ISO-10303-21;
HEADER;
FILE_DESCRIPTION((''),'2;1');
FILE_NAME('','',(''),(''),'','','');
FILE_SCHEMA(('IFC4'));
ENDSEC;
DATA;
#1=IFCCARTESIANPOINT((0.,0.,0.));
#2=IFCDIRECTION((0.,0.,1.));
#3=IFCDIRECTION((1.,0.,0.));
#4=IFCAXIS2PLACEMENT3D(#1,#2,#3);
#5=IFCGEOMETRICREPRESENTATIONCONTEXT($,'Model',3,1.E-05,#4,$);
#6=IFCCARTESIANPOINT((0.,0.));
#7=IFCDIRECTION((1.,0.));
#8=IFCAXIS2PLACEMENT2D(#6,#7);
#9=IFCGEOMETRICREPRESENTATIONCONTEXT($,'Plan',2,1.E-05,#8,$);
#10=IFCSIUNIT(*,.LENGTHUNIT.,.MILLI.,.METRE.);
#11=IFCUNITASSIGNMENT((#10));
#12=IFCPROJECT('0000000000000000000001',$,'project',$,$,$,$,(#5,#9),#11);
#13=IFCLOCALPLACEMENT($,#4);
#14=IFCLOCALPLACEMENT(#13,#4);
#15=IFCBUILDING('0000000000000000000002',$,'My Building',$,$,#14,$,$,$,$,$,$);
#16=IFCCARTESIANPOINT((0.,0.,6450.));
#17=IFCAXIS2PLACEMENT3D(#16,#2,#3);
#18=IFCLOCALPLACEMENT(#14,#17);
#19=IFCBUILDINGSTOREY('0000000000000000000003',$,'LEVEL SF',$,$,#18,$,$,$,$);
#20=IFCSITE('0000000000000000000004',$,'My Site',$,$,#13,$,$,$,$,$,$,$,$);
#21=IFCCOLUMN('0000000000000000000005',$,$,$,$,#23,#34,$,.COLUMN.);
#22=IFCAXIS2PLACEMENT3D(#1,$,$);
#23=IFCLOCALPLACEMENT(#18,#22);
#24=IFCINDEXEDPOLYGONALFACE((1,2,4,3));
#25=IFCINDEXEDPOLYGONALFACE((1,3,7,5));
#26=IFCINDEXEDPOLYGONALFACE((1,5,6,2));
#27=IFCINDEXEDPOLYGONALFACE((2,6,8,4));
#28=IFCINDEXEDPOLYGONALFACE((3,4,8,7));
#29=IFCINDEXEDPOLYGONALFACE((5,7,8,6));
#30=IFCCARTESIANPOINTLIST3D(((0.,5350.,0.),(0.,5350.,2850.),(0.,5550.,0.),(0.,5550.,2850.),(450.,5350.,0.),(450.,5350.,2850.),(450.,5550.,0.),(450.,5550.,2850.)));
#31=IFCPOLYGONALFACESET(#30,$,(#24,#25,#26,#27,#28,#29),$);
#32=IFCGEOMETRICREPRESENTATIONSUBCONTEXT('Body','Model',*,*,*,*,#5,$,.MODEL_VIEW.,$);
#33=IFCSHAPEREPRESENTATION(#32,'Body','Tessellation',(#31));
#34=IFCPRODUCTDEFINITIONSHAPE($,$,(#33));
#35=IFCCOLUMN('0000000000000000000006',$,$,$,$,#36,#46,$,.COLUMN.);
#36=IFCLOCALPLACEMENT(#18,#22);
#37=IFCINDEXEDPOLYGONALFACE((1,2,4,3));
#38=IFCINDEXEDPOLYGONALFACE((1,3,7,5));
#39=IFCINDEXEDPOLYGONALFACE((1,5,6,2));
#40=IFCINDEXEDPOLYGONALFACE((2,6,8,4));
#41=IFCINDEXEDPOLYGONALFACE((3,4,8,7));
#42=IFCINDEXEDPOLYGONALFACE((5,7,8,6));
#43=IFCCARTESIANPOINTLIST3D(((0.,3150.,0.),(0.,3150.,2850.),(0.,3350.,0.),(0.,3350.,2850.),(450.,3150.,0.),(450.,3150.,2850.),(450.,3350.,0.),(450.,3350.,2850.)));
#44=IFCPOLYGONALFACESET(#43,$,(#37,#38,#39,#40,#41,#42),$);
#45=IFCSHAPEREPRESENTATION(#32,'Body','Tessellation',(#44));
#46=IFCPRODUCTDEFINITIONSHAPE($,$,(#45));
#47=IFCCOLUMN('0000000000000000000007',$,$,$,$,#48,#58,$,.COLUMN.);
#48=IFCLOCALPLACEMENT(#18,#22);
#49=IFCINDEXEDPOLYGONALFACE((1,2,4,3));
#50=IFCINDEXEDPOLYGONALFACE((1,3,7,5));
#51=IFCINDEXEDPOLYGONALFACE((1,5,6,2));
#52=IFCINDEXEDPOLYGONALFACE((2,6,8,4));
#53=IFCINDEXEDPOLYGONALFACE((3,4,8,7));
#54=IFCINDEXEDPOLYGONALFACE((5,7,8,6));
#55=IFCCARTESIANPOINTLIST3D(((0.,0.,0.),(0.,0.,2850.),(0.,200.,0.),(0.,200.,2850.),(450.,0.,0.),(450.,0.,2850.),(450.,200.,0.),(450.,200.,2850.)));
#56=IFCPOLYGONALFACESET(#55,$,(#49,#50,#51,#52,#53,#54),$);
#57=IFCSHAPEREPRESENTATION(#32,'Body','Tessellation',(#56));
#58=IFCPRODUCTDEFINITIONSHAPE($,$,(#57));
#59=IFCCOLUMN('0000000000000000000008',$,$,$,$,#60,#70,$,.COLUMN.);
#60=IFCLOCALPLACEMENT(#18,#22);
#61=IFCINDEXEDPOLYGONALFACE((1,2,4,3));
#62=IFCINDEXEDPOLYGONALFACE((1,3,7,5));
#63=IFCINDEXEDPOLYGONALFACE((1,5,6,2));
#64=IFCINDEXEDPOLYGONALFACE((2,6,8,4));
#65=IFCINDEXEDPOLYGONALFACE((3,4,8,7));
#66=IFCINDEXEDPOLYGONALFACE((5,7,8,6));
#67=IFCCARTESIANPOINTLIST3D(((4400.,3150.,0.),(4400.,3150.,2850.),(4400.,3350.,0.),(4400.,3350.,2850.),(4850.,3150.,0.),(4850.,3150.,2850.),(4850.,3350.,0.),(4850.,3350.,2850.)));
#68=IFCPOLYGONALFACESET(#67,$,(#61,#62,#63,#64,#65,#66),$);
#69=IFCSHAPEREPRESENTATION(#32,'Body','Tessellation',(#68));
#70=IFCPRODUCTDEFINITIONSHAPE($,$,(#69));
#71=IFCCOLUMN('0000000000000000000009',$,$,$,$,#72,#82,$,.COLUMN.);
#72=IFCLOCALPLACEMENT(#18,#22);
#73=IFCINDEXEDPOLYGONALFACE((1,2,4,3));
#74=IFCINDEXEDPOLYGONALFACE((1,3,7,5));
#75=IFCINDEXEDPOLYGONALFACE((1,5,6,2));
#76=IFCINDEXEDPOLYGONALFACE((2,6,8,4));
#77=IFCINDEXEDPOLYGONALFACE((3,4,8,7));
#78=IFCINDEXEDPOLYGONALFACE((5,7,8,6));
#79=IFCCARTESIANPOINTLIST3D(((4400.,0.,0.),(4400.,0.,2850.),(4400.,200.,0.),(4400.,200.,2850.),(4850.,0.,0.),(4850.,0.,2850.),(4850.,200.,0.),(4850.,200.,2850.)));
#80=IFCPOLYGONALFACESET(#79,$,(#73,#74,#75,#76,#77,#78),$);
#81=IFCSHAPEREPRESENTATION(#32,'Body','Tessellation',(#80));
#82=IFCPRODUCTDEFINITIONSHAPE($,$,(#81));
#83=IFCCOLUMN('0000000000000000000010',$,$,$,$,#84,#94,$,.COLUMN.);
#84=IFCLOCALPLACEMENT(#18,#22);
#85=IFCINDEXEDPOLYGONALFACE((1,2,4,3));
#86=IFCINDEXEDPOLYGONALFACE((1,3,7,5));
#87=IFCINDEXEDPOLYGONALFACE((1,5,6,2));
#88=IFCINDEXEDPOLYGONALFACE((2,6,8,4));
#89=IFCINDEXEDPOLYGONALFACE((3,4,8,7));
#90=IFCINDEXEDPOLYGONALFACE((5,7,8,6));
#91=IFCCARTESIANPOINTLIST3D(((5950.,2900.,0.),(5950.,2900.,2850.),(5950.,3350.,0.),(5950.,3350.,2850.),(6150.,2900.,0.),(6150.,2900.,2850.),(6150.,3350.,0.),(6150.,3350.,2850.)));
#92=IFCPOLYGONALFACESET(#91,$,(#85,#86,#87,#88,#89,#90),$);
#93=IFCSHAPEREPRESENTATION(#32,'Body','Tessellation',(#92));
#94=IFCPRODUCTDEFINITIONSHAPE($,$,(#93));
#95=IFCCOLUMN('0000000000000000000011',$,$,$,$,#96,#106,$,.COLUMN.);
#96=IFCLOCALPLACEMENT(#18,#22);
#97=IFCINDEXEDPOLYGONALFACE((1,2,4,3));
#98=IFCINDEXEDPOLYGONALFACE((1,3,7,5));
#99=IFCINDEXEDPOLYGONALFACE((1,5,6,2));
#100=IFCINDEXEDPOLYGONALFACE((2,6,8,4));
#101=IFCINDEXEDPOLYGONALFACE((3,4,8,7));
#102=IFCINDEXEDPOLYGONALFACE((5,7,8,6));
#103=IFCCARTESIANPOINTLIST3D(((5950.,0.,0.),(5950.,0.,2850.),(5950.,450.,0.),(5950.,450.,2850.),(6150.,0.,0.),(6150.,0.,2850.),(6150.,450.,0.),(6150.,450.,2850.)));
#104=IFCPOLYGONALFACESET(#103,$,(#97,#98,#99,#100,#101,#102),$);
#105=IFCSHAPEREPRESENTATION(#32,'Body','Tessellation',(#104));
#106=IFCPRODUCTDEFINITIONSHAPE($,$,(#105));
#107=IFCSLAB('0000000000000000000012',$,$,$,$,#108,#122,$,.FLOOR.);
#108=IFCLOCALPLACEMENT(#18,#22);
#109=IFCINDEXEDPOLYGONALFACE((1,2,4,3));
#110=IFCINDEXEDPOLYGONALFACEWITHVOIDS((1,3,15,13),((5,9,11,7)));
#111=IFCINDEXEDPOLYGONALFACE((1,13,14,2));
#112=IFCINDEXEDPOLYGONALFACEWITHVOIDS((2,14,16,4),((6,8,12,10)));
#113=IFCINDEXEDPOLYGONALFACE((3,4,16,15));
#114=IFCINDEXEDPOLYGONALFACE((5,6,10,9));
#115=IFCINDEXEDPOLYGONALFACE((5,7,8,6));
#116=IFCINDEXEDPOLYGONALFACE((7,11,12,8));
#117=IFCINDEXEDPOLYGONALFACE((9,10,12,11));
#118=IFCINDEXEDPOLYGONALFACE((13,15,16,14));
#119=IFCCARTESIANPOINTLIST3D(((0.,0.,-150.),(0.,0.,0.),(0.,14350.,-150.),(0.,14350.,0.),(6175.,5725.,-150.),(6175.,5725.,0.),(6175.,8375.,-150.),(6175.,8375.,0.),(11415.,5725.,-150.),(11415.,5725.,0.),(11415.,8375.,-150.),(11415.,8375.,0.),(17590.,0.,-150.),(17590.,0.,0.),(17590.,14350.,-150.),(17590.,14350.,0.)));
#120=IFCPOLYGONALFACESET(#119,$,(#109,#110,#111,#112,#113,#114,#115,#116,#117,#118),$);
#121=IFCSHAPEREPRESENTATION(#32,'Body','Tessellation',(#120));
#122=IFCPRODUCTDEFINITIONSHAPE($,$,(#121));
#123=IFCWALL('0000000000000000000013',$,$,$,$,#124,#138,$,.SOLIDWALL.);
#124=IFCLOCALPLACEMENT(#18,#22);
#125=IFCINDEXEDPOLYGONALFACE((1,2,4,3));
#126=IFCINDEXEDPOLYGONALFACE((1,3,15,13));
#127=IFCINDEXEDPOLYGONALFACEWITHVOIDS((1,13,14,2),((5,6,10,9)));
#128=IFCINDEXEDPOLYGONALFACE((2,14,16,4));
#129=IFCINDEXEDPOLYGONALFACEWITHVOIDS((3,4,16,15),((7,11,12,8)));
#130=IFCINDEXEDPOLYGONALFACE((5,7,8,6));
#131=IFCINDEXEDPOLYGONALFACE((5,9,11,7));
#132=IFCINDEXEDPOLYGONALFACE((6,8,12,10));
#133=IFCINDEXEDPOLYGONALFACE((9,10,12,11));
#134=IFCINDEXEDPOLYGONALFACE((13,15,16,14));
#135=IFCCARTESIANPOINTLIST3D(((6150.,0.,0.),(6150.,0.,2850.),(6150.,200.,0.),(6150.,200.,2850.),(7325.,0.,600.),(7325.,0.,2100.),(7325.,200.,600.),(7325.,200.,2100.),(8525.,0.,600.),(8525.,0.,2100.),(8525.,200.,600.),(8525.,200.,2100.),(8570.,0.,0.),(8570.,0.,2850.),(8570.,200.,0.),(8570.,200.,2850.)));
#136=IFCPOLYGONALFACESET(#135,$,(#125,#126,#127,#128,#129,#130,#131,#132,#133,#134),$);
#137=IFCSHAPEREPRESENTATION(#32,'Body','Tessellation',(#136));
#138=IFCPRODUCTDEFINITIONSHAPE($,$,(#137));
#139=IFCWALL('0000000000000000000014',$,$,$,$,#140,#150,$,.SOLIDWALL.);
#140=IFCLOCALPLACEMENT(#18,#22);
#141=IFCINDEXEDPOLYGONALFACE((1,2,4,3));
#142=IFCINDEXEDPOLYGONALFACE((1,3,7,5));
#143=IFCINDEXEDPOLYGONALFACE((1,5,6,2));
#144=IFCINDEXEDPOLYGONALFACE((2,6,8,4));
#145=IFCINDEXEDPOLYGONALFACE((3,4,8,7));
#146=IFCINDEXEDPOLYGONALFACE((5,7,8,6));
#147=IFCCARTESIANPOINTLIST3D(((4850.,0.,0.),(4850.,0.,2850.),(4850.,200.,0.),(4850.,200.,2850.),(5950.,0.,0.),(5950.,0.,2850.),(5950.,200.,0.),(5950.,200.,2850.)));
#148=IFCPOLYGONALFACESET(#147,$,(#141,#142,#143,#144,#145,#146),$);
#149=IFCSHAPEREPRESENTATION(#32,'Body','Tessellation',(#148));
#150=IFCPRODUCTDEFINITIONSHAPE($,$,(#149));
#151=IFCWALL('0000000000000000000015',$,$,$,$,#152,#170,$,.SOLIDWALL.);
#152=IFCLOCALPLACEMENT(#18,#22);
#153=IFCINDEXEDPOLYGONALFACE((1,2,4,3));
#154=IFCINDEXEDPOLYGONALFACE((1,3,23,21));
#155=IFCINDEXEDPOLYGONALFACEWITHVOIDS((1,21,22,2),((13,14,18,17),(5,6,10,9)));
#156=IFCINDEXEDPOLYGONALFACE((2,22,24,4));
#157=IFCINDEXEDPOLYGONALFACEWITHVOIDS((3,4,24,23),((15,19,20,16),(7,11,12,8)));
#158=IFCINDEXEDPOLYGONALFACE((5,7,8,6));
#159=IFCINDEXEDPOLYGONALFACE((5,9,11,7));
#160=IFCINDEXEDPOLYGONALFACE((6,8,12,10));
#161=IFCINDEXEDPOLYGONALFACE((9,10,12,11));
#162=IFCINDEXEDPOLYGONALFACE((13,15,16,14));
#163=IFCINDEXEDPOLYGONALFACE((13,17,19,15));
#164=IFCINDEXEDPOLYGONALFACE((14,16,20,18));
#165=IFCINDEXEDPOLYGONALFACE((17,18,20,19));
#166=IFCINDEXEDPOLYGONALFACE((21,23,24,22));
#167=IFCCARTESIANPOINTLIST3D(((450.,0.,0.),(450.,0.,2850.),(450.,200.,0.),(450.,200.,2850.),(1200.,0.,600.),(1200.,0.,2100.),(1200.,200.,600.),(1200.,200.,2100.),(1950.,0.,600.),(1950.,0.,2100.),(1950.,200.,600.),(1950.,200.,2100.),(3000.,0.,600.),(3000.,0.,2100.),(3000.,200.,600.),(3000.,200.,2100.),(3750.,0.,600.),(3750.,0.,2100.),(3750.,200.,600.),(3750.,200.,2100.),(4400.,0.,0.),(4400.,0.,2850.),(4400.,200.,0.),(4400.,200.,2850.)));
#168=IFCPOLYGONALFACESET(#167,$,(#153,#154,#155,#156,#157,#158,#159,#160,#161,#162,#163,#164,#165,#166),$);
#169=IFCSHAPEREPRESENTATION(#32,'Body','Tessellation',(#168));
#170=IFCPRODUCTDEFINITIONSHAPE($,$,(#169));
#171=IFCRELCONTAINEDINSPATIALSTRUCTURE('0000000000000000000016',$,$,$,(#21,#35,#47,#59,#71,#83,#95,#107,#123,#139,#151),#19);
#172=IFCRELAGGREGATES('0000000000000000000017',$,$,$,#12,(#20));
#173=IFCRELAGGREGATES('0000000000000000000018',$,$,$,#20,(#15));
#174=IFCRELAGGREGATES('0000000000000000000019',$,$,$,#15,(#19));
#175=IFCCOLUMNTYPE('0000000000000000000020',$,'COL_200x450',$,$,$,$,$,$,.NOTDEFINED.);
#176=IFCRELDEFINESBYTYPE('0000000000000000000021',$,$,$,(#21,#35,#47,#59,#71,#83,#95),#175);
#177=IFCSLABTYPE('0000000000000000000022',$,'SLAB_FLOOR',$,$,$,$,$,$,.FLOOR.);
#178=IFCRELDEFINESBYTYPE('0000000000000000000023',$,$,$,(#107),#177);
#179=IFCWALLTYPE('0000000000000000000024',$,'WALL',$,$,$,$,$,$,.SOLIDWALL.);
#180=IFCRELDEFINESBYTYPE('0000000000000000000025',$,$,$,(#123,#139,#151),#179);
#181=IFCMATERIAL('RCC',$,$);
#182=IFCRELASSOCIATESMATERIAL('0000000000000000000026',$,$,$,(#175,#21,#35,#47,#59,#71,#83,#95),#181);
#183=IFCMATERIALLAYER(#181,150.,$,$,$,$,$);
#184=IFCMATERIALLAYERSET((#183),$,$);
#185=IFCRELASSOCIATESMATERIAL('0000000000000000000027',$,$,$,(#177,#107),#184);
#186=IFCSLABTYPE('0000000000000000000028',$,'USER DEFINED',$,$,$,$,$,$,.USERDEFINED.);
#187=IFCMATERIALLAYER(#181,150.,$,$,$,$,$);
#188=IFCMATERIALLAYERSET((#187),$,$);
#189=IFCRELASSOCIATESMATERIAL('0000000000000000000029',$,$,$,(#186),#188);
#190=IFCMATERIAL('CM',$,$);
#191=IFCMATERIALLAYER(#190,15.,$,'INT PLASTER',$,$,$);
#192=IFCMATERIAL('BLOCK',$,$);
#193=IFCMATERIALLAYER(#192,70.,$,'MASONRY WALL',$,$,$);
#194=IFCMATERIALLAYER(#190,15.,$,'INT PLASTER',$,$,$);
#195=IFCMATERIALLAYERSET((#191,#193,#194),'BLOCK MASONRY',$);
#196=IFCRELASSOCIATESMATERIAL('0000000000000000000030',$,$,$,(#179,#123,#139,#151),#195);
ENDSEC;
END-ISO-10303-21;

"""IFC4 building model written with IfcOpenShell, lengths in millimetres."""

from ifc_helpers import new_model, si_unit, frame, origin_with_axes, origin_2d_with_axis, place, context, subcontext, project, spatial, indexed_curve, rectangle, outline, extrude, material, layer, layer_set, layer_usage, material_profile, profile_set, profile_usage, type_object, element, save


model = new_model("IFC4")

# Units and contexts
model_context = context("Model", 3, precision=1e-05, world=origin_with_axes())
plan_context = context("Plan", 2, precision=1e-05, world=origin_2d_with_axis())
body_context = subcontext(model_context, "Body", "Model", "MODEL_VIEW")
ifc_project = project(units=[si_unit("LENGTHUNIT", "METRE", prefix="MILLI")], contexts=[model_context, plan_context])

# Site, building, storey
site_placement = place(None, origin_with_axes())
site = spatial("IfcSite", under=ifc_project, at=site_placement, Name="My Site")
building_placement = place(site_placement, origin_with_axes())
building = spatial("IfcBuilding", under=site, at=building_placement, Name="My Building")
storey_placement = place(building_placement, frame((0.0, 0.0, 6450.0), z_axis=(0.0, 0.0, 1.0), x_axis=(1.0, 0.0, 0.0)))
storey = spatial("IfcBuildingStorey", under=building, at=storey_placement, Name="LEVEL SF")

# Columns
ifc_material_1 = material(Name="RCC")
ifc_material_profile = material_profile(ifc_material_1, rectangle(XDim=200.0, YDim=450.0))
ifc_profile_set = profile_set([ifc_material_profile], Name="COL_200x450")
ifc_profile_usage_1 = profile_usage(ifc_profile_set)
column_type = type_object("IfcColumnType", Name="COL_200x450", PredefinedType="NOTDEFINED", material=ifc_profile_set)
column_1_placement = place(storey_placement, frame((225.0, 5450.0, 0.0), z_axis=(0.0, 0.0, 1.0), x_axis=(0.0, -1.0, 0.0)))
element("IfcColumn", 1, at=column_1_placement, inside=storey, type_object=column_type, material=ifc_profile_usage_1, PredefinedType="COLUMN", context=body_context, shape_type="SweptSolid", body=[
    extrude(rectangle(XDim=200.0, YDim=450.0), origin_with_axes(), (0.0, 0.0, 1.0), 2850.0),
])
ifc_profile_usage_2 = profile_usage(ifc_profile_set)
column_2_placement = place(storey_placement, frame((225.0, 3250.0, 0.0), z_axis=(0.0, 0.0, 1.0), x_axis=(0.0, -1.0, 0.0)))
element("IfcColumn", 2, at=column_2_placement, inside=storey, type_object=column_type, material=ifc_profile_usage_2, PredefinedType="COLUMN", context=body_context, shape_type="SweptSolid", body=[
    extrude(rectangle(XDim=200.0, YDim=450.0), origin_with_axes(), (0.0, 0.0, 1.0), 2850.0),
])
ifc_profile_usage_3 = profile_usage(ifc_profile_set)
column_3_placement = place(storey_placement, frame((225.0, 100.0, 0.0), z_axis=(0.0, 0.0, 1.0), x_axis=(0.0, -1.0, 0.0)))
element("IfcColumn", 3, at=column_3_placement, inside=storey, type_object=column_type, material=ifc_profile_usage_3, PredefinedType="COLUMN", context=body_context, shape_type="SweptSolid", body=[
    extrude(rectangle(XDim=200.0, YDim=450.0), origin_with_axes(), (0.0, 0.0, 1.0), 2850.0),
])
ifc_profile_usage_4 = profile_usage(ifc_profile_set)
column_4_placement = place(storey_placement, frame((4625.0, 3250.0, 0.0), z_axis=(0.0, 0.0, 1.0), x_axis=(0.0, -1.0, 0.0)))
element("IfcColumn", 4, at=column_4_placement, inside=storey, type_object=column_type, material=ifc_profile_usage_4, PredefinedType="COLUMN", context=body_context, shape_type="SweptSolid", body=[
    extrude(rectangle(XDim=200.0, YDim=450.0), origin_with_axes(), (0.0, 0.0, 1.0), 2850.0),
])
ifc_profile_usage_5 = profile_usage(ifc_profile_set)
column_5_placement = place(storey_placement, frame((4625.0, 100.0, 0.0), z_axis=(0.0, 0.0, 1.0), x_axis=(0.0, -1.0, 0.0)))
element("IfcColumn", 5, at=column_5_placement, inside=storey, type_object=column_type, material=ifc_profile_usage_5, PredefinedType="COLUMN", context=body_context, shape_type="SweptSolid", body=[
    extrude(rectangle(XDim=200.0, YDim=450.0), origin_with_axes(), (0.0, 0.0, 1.0), 2850.0),
])
ifc_profile_usage_6 = profile_usage(ifc_profile_set)
column_6_placement = place(storey_placement, frame((6050.0, 3125.0, 0.0), z_axis=(0.0, 0.0, 1.0), x_axis=(1.0, 0.0, 0.0)))
element("IfcColumn", 6, at=column_6_placement, inside=storey, type_object=column_type, material=ifc_profile_usage_6, PredefinedType="COLUMN", context=body_context, shape_type="SweptSolid", body=[
    extrude(rectangle(XDim=200.0, YDim=450.0), origin_with_axes(), (0.0, 0.0, 1.0), 2850.0),
])
ifc_profile_usage_7 = profile_usage(ifc_profile_set)
column_7_placement = place(storey_placement, frame((6050.0, 225.0, 0.0), z_axis=(0.0, 0.0, 1.0), x_axis=(1.0, 0.0, 0.0)))
element("IfcColumn", 7, at=column_7_placement, inside=storey, type_object=column_type, material=ifc_profile_usage_7, PredefinedType="COLUMN", context=body_context, shape_type="SweptSolid", body=[
    extrude(rectangle(XDim=200.0, YDim=450.0), origin_with_axes(), (0.0, 0.0, 1.0), 2850.0),
])

# Slab, opening
ifc_layer_1 = layer(ifc_material_1, 150.0)
ifc_layer_set_1 = layer_set([ifc_layer_1])
ifc_layer_usage_1 = layer_usage(ifc_layer_set_1, "AXIS3", "POSITIVE", 0.0)
slab_type_1 = type_object("IfcSlabType", Name="SLAB_FLOOR", PredefinedType="FLOOR", material=ifc_layer_set_1)
slab_placement = place(storey_placement, frame((0.0, 0.0, -150.0), z_axis=(0.0, 0.0, 1.0), x_axis=(1.0, 0.0, 0.0)))
slab = element("IfcSlab", 8, at=slab_placement, inside=storey, type_object=slab_type_1, material=ifc_layer_usage_1, PredefinedType="FLOOR", context=body_context, shape_type="SweptSolid", body=[
    extrude(outline(indexed_curve([(0.0, 14350.0), (17590.0, 14350.0), (17590.0, 0.0), (0.0, 0.0)])), None, (0.0, 0.0, 1.0), 150.0),
])
ifc_layer_2 = layer(ifc_material_1, 150.0)
ifc_layer_set_2 = layer_set([ifc_layer_2])
ifc_layer_usage_2 = layer_usage(ifc_layer_set_2, "AXIS3", "POSITIVE", 0.0)
slab_type_2 = type_object("IfcSlabType", Name="USER DEFINED", PredefinedType="USERDEFINED", material=ifc_layer_set_2)
opening_1_placement = place(slab_placement, origin_with_axes())
element("IfcOpeningElement", 9, at=opening_1_placement, cuts=slab, type_object=slab_type_2, material=ifc_layer_usage_2, ObjectType="FLOORCUTOUT", PredefinedType="OPENING", context=body_context, shape_type="SweptSolid", body=[
    extrude(outline(indexed_curve([(6175.0, 5725.0), (6175.0, 8375.0), (11415.0, 8375.0), (11415.0, 5725.0)])), None, (0.0, 0.0, 1.0), 150.0),
])

# Wall, opening
ifc_material_2 = material(Name="CM")
ifc_layer_3 = layer(ifc_material_2, 15.0, Name="INT PLASTER")
ifc_material_3 = material(Name="BLOCK")
ifc_layer_4 = layer(ifc_material_3, 70.0, Name="MASONRY WALL")
ifc_layer_5 = layer(ifc_material_2, 15.0, Name="INT PLASTER")
ifc_layer_set_3 = layer_set([ifc_layer_3, ifc_layer_4, ifc_layer_5], Name="BLOCK MASONRY")
ifc_layer_usage_3 = layer_usage(ifc_layer_set_3, "AXIS2", "POSITIVE", 0.0)
wall_type = type_object("IfcWallType", Name="WALL", PredefinedType="SOLIDWALL", material=ifc_layer_set_3)
wall_1_placement = place(storey_placement, frame((6150.0, 200.0, 0.0), z_axis=(0.0, 0.0, 1.0), x_axis=(0.0, -1.0, 0.0)))
wall_1 = element("IfcWall", 10, at=wall_1_placement, inside=storey, type_object=wall_type, material=ifc_layer_usage_3, PredefinedType="SOLIDWALL", context=body_context, shape_type="SweptSolid", body=[
    extrude(outline(indexed_curve([(0.0, 0.0), (0.0, 2420.0), (200.0, 2420.0), (200.0, 0.0), (0.0, 0.0)], self_intersect=False)), origin_with_axes(), (0.0, 0.0, 1.0), 2850.0),
])
opening_2_placement = place(wall_1_placement, frame((0.0, 2375.0, 600.0), z_axis=(0.0, 0.0, 1.0), x_axis=(0.0, -1.0, 0.0)))
element("IfcOpeningElement", 11, at=opening_2_placement, cuts=wall_1, PredefinedType="OPENING", context=body_context, shape_type="SweptSolid", body=[
    extrude(outline(indexed_curve([(0.0, 0.0), (0.0, 400.0), (1200.0, 400.0), (1200.0, 0.0), (0.0, 0.0)], self_intersect=False)), frame((0.0, -100.0, 0.0), z_axis=(0.0, 0.0, 1.0), x_axis=(1.0, 0.0, 0.0)), (0.0, 0.0, 1.0), 1500.0),
])

# Wall
ifc_layer_usage_4 = layer_usage(ifc_layer_set_3, "AXIS2", "POSITIVE", 0.0)
wall_2_placement = place(storey_placement, frame((4850.0, 200.0, 0.0), z_axis=(0.0, 0.0, 1.0), x_axis=(0.0, -1.0, 0.0)))
element("IfcWall", 12, at=wall_2_placement, inside=storey, type_object=wall_type, material=ifc_layer_usage_4, PredefinedType="SOLIDWALL", context=body_context, shape_type="SweptSolid", body=[
    extrude(outline(indexed_curve([(0.0, 0.0), (0.0, 1100.0), (200.0, 1100.0), (200.0, 0.0), (0.0, 0.0)], self_intersect=False)), origin_with_axes(), (0.0, 0.0, 1.0), 2850.0),
])

# Wall, openings
ifc_layer_usage_5 = layer_usage(ifc_layer_set_3, "AXIS2", "POSITIVE", 0.0)
wall_3_placement = place(storey_placement, frame((450.0, 200.0, 0.0), z_axis=(0.0, 0.0, 1.0), x_axis=(0.0, -1.0, 0.0)))
wall_3 = element("IfcWall", 13, at=wall_3_placement, inside=storey, type_object=wall_type, material=ifc_layer_usage_5, PredefinedType="SOLIDWALL", context=body_context, shape_type="SweptSolid", body=[
    extrude(outline(indexed_curve([(0.0, 0.0), (0.0, 3950.0), (200.0, 3950.0), (200.0, 0.0), (0.0, 0.0)], self_intersect=False)), origin_with_axes(), (0.0, 0.0, 1.0), 2850.0),
])
opening_3_placement = place(wall_3_placement, frame((0.0, 1500.0, 600.0), z_axis=(0.0, 0.0, 1.0), x_axis=(0.0, -1.0, 0.0)))
element("IfcOpeningElement", 14, at=opening_3_placement, cuts=wall_3, PredefinedType="OPENING", context=body_context, shape_type="SweptSolid", body=[
    extrude(outline(indexed_curve([(0.0, 0.0), (0.0, 400.0), (750.0, 400.0), (750.0, 0.0), (0.0, 0.0)], self_intersect=False)), frame((0.0, -100.0, 0.0), z_axis=(0.0, 0.0, 1.0), x_axis=(1.0, 0.0, 0.0)), (0.0, 0.0, 1.0), 1500.0),
])
opening_4_placement = place(wall_3_placement, frame((0.0, 3300.0, 600.0), z_axis=(0.0, 0.0, 1.0), x_axis=(0.0, -1.0, 0.0)))
element("IfcOpeningElement", 15, at=opening_4_placement, cuts=wall_3, PredefinedType="OPENING", context=body_context, shape_type="SweptSolid", body=[
    extrude(outline(indexed_curve([(0.0, 0.0), (0.0, 400.0), (750.0, 400.0), (750.0, 0.0), (0.0, 0.0)], self_intersect=False)), frame((0.0, -100.0, 0.0), z_axis=(0.0, 0.0, 1.0), x_axis=(1.0, 0.0, 0.0)), (0.0, 0.0, 1.0), 1500.0),
])

save(model, "model.ifc")
